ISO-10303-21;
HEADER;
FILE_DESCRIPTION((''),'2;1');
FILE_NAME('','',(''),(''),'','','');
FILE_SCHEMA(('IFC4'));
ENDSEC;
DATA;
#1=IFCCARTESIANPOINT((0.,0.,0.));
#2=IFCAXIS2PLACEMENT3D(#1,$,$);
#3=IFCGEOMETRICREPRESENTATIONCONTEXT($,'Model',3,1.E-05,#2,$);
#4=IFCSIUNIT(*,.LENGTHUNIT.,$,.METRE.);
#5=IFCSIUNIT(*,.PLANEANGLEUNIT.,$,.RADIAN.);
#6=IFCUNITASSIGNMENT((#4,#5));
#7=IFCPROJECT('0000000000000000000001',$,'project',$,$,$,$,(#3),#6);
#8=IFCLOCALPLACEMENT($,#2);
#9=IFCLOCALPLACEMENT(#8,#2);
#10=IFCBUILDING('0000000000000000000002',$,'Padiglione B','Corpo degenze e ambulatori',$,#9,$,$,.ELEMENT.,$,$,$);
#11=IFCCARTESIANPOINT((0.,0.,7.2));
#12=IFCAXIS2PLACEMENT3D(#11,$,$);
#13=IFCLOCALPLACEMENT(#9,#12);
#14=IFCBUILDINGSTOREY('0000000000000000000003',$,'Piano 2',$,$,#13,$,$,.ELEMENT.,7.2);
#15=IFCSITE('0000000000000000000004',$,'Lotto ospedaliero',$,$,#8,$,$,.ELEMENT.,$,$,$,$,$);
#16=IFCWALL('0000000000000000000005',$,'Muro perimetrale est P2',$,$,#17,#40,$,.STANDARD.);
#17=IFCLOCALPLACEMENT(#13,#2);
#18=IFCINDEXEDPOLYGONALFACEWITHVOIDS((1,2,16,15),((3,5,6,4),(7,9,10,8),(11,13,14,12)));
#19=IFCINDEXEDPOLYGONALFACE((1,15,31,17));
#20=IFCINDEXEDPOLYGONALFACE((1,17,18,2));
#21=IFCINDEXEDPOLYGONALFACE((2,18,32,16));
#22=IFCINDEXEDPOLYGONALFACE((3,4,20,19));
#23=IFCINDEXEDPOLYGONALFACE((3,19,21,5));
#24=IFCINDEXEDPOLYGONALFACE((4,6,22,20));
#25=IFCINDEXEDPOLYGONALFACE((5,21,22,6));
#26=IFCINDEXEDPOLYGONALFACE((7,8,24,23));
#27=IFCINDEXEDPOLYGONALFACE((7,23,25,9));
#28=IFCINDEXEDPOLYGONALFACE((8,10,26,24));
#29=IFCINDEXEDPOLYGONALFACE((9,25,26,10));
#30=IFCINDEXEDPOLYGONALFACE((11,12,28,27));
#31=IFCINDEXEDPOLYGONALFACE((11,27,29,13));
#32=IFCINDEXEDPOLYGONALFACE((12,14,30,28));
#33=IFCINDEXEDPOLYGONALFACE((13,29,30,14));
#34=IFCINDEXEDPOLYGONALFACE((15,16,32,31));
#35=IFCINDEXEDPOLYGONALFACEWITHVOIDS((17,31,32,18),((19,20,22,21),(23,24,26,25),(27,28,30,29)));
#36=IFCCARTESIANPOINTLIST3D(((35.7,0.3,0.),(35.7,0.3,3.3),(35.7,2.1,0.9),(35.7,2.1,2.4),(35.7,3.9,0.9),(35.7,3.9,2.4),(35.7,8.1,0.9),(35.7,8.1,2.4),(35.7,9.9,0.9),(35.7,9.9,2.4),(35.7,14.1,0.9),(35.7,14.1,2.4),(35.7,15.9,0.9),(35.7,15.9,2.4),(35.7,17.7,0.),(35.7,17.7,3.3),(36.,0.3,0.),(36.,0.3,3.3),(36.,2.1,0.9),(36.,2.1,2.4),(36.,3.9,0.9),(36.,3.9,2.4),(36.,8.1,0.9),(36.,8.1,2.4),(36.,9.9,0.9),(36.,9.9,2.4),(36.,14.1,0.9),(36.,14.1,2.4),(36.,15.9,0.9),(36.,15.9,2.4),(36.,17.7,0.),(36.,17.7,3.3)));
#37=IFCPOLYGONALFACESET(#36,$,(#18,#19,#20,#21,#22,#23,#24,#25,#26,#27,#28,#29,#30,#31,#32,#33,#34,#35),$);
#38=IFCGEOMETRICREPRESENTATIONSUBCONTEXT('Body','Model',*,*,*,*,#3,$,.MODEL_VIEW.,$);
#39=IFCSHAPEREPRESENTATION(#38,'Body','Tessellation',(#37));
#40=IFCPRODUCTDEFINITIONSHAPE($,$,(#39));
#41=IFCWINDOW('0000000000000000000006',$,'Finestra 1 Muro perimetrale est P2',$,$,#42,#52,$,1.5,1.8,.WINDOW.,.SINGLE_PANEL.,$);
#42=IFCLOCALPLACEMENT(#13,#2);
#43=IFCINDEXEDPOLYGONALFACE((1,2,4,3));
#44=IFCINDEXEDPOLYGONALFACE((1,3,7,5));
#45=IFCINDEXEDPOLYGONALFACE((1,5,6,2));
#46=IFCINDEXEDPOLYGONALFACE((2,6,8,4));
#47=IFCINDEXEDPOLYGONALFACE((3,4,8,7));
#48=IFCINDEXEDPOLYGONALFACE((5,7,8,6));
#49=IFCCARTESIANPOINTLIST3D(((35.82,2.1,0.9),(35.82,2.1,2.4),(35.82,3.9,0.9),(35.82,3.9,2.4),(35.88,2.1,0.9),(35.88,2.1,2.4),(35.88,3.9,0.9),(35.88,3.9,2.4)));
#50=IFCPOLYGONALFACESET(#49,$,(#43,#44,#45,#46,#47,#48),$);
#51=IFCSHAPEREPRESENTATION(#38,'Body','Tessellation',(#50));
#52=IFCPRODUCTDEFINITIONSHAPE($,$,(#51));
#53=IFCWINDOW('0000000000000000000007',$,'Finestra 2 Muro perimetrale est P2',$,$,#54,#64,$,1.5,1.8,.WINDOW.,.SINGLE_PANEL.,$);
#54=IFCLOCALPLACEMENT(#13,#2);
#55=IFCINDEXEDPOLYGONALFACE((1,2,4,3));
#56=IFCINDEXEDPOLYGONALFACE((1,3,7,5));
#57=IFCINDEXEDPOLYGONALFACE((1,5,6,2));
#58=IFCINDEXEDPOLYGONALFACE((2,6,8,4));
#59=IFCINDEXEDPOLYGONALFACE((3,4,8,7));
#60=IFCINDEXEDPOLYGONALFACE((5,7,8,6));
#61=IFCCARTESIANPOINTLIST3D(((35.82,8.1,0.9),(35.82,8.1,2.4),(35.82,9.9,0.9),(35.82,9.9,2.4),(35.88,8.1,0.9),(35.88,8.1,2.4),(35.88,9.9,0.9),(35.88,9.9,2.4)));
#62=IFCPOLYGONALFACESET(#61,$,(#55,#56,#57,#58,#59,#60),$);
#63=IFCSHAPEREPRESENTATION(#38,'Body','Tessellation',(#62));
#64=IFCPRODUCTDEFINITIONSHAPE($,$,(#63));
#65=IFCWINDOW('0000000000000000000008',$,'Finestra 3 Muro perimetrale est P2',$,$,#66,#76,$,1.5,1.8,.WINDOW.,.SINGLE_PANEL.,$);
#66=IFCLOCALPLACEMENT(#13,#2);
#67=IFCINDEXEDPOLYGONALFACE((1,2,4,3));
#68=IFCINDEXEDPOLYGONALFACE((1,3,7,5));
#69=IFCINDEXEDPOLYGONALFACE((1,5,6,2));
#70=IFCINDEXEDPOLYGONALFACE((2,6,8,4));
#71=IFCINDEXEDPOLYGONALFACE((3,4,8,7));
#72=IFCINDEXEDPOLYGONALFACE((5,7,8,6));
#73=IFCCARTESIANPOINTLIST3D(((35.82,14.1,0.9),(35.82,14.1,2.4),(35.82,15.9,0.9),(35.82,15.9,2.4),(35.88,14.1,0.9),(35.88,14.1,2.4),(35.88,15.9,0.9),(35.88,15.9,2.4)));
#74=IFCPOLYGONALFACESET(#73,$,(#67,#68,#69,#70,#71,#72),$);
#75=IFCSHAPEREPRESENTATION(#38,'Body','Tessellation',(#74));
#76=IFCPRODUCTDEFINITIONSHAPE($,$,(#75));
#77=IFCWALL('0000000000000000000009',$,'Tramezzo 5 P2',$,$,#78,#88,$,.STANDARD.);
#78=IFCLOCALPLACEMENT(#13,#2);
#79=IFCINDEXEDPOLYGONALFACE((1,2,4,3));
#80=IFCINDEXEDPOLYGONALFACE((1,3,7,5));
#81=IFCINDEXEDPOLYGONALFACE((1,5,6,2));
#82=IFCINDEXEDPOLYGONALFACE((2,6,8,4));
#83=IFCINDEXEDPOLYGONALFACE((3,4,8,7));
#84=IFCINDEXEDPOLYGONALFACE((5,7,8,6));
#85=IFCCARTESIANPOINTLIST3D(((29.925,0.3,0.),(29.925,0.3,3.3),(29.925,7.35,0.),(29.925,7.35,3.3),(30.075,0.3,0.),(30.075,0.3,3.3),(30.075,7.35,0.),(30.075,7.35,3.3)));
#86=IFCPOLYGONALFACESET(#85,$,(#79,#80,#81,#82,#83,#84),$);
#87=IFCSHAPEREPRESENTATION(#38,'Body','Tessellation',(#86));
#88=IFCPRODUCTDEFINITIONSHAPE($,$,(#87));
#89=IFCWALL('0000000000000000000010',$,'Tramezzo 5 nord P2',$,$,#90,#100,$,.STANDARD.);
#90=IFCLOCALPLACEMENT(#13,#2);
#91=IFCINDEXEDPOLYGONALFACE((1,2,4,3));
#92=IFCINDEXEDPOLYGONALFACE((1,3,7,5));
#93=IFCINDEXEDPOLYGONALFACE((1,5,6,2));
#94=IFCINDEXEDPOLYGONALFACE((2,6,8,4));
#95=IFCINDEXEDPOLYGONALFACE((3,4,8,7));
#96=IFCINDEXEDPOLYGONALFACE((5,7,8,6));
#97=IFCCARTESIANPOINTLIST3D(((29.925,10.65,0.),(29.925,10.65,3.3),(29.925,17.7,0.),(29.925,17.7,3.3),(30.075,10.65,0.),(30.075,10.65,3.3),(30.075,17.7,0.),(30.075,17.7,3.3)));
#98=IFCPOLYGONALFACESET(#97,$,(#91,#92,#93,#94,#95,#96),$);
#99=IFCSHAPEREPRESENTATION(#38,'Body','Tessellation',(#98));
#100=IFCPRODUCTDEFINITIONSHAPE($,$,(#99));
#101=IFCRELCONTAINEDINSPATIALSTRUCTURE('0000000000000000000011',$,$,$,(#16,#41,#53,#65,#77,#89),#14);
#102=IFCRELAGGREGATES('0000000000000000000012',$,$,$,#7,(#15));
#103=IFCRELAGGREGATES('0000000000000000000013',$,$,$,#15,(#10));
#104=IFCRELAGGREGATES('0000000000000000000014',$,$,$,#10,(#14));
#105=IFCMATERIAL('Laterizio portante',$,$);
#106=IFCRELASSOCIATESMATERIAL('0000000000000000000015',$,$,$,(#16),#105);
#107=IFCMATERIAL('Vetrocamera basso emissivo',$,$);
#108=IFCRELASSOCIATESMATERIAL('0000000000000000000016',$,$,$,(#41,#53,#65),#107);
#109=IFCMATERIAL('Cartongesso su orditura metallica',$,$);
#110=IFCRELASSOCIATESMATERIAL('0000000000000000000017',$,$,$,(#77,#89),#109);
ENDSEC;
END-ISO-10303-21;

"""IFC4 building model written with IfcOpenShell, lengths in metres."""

from ifc_helpers import new_model, si_unit, frame, frame_2d, origin, place, context, subcontext, project, spatial, rectangle, extrude, material, element, fill, save


model = new_model("IFC4")

# Units and contexts
model_context = context("Model", 3, precision=1e-05, world=origin())
body_context = subcontext(model_context, "Body", "Model", "MODEL_VIEW")
ifc_project = project(units=[si_unit("LENGTHUNIT", "METRE"), si_unit("PLANEANGLEUNIT", "RADIAN")], contexts=[model_context])

# Site, building, storey
site_placement = place(None, origin())
site = spatial("IfcSite", under=ifc_project, at=site_placement, Name="Lotto ospedaliero", CompositionType="ELEMENT")
building_placement = place(site_placement, origin())
building = spatial("IfcBuilding", under=site, at=building_placement, Name="Padiglione B", Description="Corpo degenze e ambulatori", CompositionType="ELEMENT")
storey_placement = place(building_placement, frame((0.0, 0.0, 7.2)))
storey = spatial("IfcBuildingStorey", under=building, at=storey_placement, Name="Piano 2", CompositionType="ELEMENT", Elevation=7.2)

# Wall, openings, windows
ifc_material_1 = material(Name="Laterizio portante")
wall_placement = place(storey_placement, frame((35.7, 0.3, 0.0)))
wall = element("IfcWall", 1, at=wall_placement, inside=storey, material=ifc_material_1, Name="Muro perimetrale est P2", PredefinedType="STANDARD", context=body_context, shape_type="SweptSolid", body=[
    extrude(rectangle(XDim=0.3, YDim=17.4, at=frame_2d((0.15, 8.7))), origin(), (0.0, 0.0, 1.0), 3.3),
])
opening_1_placement = place(wall_placement, frame((-0.1, 1.8, 0.9)))
opening_1 = element("IfcOpeningElement", 2, at=opening_1_placement, cuts=wall, PredefinedType="OPENING", context=body_context, shape_type="SweptSolid", body=[
    extrude(rectangle(XDim=0.5, YDim=1.8, at=frame_2d((0.25, 0.9))), origin(), (0.0, 0.0, 1.0), 1.5),
])
opening_2_placement = place(wall_placement, frame((-0.1, 7.8, 0.9)))
opening_2 = element("IfcOpeningElement", 3, at=opening_2_placement, cuts=wall, PredefinedType="OPENING", context=body_context, shape_type="SweptSolid", body=[
    extrude(rectangle(XDim=0.5, YDim=1.8, at=frame_2d((0.25, 0.9))), origin(), (0.0, 0.0, 1.0), 1.5),
])
opening_3_placement = place(wall_placement, frame((-0.1, 13.8, 0.9)))
opening_3 = element("IfcOpeningElement", 4, at=opening_3_placement, cuts=wall, PredefinedType="OPENING", context=body_context, shape_type="SweptSolid", body=[
    extrude(rectangle(XDim=0.5, YDim=1.8, at=frame_2d((0.25, 0.9))), origin(), (0.0, 0.0, 1.0), 1.5),
])
ifc_material_2 = material(Name="Vetrocamera basso emissivo")
window_1_placement = place(wall_placement, frame((0.12, 1.8, 0.9)))
window_1 = element("IfcWindow", 5, at=window_1_placement, inside=storey, material=ifc_material_2, Name="Finestra 1 Muro perimetrale est P2", OverallHeight=1.5, OverallWidth=1.8, PartitioningType="SINGLE_PANEL", PredefinedType="WINDOW", context=body_context, shape_type="SweptSolid", body=[
    extrude(rectangle(XDim=0.06, YDim=1.8, at=frame_2d((0.03, 0.9))), origin(), (0.0, 0.0, 1.0), 1.5),
])
fill(opening_1, window_1)
window_2_placement = place(wall_placement, frame((0.12, 7.8, 0.9)))
window_2 = element("IfcWindow", 6, at=window_2_placement, inside=storey, material=ifc_material_2, Name="Finestra 2 Muro perimetrale est P2", OverallHeight=1.5, OverallWidth=1.8, PartitioningType="SINGLE_PANEL", PredefinedType="WINDOW", context=body_context, shape_type="SweptSolid", body=[
    extrude(rectangle(XDim=0.06, YDim=1.8, at=frame_2d((0.03, 0.9))), origin(), (0.0, 0.0, 1.0), 1.5),
])
fill(opening_2, window_2)
window_3_placement = place(wall_placement, frame((0.12, 13.8, 0.9)))
window_3 = element("IfcWindow", 7, at=window_3_placement, inside=storey, material=ifc_material_2, Name="Finestra 3 Muro perimetrale est P2", OverallHeight=1.5, OverallWidth=1.8, PartitioningType="SINGLE_PANEL", PredefinedType="WINDOW", context=body_context, shape_type="SweptSolid", body=[
    extrude(rectangle(XDim=0.06, YDim=1.8, at=frame_2d((0.03, 0.9))), origin(), (0.0, 0.0, 1.0), 1.5),
])
fill(opening_3, window_3)

# Walls
ifc_material_3 = material(Name="Cartongesso su orditura metallica")
for number, where, name in (
    (8, (29.925, 0.3, 0.0), "Tramezzo 5 P2"),
    (9, (29.925, 10.65, 0.0), "Tramezzo 5 nord P2"),
):
    element("IfcWall", number, at=place(storey_placement, frame(where)), inside=storey, material=ifc_material_3, Name=name, PredefinedType="STANDARD", context=body_context, shape_type="SweptSolid", body=[
        extrude(rectangle(XDim=0.15, YDim=7.05, at=frame_2d((0.075, 3.525))), origin(), (0.0, 0.0, 1.0), 3.3),
    ])

save(model, "model.ifc")
